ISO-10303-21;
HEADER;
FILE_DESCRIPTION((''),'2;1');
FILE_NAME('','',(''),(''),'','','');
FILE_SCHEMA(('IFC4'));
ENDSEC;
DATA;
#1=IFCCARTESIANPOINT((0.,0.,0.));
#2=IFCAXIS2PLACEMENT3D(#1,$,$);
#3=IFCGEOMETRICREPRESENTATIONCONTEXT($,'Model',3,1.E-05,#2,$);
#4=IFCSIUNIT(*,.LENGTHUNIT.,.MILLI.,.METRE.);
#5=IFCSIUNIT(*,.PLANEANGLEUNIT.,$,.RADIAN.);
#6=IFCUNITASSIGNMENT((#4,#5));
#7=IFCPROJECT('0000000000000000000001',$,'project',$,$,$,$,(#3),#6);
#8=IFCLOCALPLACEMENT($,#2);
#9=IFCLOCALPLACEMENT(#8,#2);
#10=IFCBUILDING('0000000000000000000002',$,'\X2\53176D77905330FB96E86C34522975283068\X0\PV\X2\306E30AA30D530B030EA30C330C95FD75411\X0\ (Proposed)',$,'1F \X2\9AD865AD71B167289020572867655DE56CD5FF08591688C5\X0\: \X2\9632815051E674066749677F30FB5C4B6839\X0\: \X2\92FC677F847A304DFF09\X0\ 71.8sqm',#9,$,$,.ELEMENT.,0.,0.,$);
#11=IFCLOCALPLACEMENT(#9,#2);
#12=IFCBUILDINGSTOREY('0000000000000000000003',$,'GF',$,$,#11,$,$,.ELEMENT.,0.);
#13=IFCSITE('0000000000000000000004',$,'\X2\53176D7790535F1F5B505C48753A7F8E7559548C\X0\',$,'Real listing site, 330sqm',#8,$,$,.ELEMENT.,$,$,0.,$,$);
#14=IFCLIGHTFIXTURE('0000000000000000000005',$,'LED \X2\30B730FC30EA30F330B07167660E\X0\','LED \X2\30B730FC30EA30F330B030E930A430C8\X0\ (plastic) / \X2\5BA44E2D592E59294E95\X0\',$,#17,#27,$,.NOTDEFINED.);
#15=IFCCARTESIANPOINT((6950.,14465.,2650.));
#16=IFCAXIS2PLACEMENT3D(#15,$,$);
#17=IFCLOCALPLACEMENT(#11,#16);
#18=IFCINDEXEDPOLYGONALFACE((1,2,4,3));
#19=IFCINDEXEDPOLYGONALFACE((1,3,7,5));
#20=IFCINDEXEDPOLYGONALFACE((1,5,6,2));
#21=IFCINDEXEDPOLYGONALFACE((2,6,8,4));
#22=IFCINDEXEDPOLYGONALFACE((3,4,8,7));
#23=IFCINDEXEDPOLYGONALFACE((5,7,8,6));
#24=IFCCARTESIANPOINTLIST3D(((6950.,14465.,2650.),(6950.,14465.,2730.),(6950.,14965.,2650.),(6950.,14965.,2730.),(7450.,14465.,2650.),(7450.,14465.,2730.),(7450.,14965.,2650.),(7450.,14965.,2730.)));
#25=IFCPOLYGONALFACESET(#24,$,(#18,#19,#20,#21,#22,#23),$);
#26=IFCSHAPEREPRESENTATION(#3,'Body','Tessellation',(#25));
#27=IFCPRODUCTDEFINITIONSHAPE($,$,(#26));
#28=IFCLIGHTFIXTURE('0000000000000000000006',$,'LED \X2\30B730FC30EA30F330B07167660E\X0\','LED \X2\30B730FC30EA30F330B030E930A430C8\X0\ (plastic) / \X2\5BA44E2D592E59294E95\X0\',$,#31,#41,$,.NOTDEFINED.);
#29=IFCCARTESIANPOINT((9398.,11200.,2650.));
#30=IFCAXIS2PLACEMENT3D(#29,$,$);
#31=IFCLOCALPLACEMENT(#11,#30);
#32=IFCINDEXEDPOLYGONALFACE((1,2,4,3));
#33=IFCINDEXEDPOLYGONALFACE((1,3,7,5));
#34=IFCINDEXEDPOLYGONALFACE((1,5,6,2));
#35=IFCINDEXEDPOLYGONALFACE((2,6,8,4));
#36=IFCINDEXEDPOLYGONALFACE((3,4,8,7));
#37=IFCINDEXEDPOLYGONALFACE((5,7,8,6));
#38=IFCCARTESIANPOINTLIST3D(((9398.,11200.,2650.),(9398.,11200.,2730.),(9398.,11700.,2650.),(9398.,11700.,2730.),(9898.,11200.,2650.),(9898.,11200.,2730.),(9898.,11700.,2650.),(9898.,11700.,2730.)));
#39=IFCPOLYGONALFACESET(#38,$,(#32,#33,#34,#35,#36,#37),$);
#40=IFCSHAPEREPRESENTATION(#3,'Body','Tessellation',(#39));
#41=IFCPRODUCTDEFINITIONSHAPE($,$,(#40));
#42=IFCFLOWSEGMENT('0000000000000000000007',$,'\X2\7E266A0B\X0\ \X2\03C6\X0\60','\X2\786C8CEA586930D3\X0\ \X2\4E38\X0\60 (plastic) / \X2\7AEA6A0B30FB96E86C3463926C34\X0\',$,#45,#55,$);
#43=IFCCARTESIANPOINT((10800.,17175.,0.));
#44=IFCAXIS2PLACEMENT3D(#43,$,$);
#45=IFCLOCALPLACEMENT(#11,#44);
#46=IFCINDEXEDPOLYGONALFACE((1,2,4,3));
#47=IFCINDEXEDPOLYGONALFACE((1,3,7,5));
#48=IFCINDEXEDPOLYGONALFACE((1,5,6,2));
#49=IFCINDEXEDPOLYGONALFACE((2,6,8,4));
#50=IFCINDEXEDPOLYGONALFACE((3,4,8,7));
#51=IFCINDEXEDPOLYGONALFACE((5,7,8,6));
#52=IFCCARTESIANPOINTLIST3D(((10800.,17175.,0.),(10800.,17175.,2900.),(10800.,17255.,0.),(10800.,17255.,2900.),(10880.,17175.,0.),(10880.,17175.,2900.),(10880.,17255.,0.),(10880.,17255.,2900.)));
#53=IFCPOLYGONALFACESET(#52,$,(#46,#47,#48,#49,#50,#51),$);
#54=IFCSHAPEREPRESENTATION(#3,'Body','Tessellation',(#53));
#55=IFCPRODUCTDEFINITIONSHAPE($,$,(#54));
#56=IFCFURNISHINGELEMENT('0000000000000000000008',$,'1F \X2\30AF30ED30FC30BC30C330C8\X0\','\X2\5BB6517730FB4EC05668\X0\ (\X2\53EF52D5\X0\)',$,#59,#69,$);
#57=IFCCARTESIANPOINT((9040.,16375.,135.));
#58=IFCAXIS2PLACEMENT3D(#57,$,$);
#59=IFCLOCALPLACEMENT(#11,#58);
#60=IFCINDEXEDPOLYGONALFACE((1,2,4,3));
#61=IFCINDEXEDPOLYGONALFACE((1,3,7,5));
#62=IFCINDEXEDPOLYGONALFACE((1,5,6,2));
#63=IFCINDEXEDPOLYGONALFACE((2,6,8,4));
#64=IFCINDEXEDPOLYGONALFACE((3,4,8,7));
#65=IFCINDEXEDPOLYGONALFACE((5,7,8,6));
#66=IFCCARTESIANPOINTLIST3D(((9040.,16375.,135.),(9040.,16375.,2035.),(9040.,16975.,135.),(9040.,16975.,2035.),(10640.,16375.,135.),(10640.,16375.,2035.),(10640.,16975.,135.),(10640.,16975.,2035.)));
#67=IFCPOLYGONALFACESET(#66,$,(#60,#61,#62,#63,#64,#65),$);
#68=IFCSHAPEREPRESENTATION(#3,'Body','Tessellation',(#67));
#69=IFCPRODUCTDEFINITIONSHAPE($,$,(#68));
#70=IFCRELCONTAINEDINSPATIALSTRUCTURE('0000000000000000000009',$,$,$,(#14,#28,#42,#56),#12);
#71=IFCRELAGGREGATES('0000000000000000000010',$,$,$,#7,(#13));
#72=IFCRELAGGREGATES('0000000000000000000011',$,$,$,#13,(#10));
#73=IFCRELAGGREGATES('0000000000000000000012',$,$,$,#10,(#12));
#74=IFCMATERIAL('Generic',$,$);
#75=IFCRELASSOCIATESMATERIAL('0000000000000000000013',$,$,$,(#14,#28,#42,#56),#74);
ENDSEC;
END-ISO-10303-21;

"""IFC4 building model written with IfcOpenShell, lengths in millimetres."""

from ifc_helpers import new_model, si_unit, frame, frame_2d, origin, place, context, project, spatial, rectangle, extrude, material, element, save


model = new_model("IFC4")

# Units and contexts
model_context = context("Model", 3, precision=1e-05, world=origin())
ifc_project = project(units=[si_unit("LENGTHUNIT", "METRE", prefix="MILLI"), si_unit("PLANEANGLEUNIT", "RADIAN")], contexts=[model_context])

# Site, building, storey
site_placement = place(None, origin())
site = spatial("IfcSite", under=ifc_project, at=site_placement, Name="北海道弟子屈町美留和", ObjectType="Real listing site, 330sqm", CompositionType="ELEMENT", RefElevation=0.0)
building_placement = place(site_placement, origin())
building = spatial("IfcBuilding", under=site, at=building_placement, Name="北海道・雨水利用とPVのオフグリッド志向 (Proposed)", ObjectType="1F 高断熱木造在来工法（外装: 防腐処理杉板・屋根: 鋼板葺き） 71.8sqm", CompositionType="ELEMENT", ElevationOfRefHeight=0.0, ElevationOfTerrain=0.0)
storey_placement = place(building_placement, origin())
storey = spatial("IfcBuildingStorey", under=building, at=storey_placement, Name="GF", CompositionType="ELEMENT", Elevation=0.0)

# Shared definitions
ifc_material_1 = material(Name="Generic")

# Light fixtures
light_fixture_1_placement = place(storey_placement, frame((6950.0, 14465.0, 2650.0)))
element("IfcLightFixture", 1, at=light_fixture_1_placement, inside=storey, material=ifc_material_1, Name="LED シーリング照明", Description="LED シーリングライト (plastic) / 室中央天井", PredefinedType="NOTDEFINED", context=model_context, shape_type="SweptSolid", body=[
    extrude(rectangle(XDim=500.0, YDim=500.0, at=frame_2d((250.0, 250.0))), frame((6950.0, 14465.0, 2650.0)), (0.0, 0.0, 1.0), 80.0),
])
light_fixture_2_placement = place(storey_placement, frame((9398.0, 11200.0, 2650.0)))
element("IfcLightFixture", 2, at=light_fixture_2_placement, inside=storey, material=ifc_material_1, Name="LED シーリング照明", Description="LED シーリングライト (plastic) / 室中央天井", PredefinedType="NOTDEFINED", context=model_context, shape_type="SweptSolid", body=[
    extrude(rectangle(XDim=500.0, YDim=500.0, at=frame_2d((250.0, 250.0))), frame((9398.0, 11200.0, 2650.0)), (0.0, 0.0, 1.0), 80.0),
])

# Flow segment
flow_segment_placement = place(storey_placement, frame((10800.0, 17175.0, 0.0)))
element("IfcFlowSegment", 3, at=flow_segment_placement, inside=storey, material=ifc_material_1, Name="縦樋 φ60", Description="硬質塩ビ 丸60 (plastic) / 竪樋・雨水排水", context=model_context, shape_type="SweptSolid", body=[
    extrude(rectangle(XDim=80.0, YDim=80.0, at=frame_2d((40.0, 40.0))), frame((10800.0, 17175.0, 0.0)), (0.0, 0.0, 1.0), 2900.0),
])

# Furnishing element
furnishing_placement = place(storey_placement, frame((9040.0, 16375.0, 135.0)))
element("IfcFurnishingElement", 4, at=furnishing_placement, inside=storey, material=ifc_material_1, Name="1F クローゼット", Description="家具・什器 (可動)", context=model_context, shape_type="SweptSolid", body=[
    extrude(rectangle(XDim=1600.0, YDim=600.0, at=frame_2d((800.0, 300.0))), frame((9040.0, 16375.0, 135.0)), (0.0, 0.0, 1.0), 1900.0),
])

save(model, "model.ifc")
